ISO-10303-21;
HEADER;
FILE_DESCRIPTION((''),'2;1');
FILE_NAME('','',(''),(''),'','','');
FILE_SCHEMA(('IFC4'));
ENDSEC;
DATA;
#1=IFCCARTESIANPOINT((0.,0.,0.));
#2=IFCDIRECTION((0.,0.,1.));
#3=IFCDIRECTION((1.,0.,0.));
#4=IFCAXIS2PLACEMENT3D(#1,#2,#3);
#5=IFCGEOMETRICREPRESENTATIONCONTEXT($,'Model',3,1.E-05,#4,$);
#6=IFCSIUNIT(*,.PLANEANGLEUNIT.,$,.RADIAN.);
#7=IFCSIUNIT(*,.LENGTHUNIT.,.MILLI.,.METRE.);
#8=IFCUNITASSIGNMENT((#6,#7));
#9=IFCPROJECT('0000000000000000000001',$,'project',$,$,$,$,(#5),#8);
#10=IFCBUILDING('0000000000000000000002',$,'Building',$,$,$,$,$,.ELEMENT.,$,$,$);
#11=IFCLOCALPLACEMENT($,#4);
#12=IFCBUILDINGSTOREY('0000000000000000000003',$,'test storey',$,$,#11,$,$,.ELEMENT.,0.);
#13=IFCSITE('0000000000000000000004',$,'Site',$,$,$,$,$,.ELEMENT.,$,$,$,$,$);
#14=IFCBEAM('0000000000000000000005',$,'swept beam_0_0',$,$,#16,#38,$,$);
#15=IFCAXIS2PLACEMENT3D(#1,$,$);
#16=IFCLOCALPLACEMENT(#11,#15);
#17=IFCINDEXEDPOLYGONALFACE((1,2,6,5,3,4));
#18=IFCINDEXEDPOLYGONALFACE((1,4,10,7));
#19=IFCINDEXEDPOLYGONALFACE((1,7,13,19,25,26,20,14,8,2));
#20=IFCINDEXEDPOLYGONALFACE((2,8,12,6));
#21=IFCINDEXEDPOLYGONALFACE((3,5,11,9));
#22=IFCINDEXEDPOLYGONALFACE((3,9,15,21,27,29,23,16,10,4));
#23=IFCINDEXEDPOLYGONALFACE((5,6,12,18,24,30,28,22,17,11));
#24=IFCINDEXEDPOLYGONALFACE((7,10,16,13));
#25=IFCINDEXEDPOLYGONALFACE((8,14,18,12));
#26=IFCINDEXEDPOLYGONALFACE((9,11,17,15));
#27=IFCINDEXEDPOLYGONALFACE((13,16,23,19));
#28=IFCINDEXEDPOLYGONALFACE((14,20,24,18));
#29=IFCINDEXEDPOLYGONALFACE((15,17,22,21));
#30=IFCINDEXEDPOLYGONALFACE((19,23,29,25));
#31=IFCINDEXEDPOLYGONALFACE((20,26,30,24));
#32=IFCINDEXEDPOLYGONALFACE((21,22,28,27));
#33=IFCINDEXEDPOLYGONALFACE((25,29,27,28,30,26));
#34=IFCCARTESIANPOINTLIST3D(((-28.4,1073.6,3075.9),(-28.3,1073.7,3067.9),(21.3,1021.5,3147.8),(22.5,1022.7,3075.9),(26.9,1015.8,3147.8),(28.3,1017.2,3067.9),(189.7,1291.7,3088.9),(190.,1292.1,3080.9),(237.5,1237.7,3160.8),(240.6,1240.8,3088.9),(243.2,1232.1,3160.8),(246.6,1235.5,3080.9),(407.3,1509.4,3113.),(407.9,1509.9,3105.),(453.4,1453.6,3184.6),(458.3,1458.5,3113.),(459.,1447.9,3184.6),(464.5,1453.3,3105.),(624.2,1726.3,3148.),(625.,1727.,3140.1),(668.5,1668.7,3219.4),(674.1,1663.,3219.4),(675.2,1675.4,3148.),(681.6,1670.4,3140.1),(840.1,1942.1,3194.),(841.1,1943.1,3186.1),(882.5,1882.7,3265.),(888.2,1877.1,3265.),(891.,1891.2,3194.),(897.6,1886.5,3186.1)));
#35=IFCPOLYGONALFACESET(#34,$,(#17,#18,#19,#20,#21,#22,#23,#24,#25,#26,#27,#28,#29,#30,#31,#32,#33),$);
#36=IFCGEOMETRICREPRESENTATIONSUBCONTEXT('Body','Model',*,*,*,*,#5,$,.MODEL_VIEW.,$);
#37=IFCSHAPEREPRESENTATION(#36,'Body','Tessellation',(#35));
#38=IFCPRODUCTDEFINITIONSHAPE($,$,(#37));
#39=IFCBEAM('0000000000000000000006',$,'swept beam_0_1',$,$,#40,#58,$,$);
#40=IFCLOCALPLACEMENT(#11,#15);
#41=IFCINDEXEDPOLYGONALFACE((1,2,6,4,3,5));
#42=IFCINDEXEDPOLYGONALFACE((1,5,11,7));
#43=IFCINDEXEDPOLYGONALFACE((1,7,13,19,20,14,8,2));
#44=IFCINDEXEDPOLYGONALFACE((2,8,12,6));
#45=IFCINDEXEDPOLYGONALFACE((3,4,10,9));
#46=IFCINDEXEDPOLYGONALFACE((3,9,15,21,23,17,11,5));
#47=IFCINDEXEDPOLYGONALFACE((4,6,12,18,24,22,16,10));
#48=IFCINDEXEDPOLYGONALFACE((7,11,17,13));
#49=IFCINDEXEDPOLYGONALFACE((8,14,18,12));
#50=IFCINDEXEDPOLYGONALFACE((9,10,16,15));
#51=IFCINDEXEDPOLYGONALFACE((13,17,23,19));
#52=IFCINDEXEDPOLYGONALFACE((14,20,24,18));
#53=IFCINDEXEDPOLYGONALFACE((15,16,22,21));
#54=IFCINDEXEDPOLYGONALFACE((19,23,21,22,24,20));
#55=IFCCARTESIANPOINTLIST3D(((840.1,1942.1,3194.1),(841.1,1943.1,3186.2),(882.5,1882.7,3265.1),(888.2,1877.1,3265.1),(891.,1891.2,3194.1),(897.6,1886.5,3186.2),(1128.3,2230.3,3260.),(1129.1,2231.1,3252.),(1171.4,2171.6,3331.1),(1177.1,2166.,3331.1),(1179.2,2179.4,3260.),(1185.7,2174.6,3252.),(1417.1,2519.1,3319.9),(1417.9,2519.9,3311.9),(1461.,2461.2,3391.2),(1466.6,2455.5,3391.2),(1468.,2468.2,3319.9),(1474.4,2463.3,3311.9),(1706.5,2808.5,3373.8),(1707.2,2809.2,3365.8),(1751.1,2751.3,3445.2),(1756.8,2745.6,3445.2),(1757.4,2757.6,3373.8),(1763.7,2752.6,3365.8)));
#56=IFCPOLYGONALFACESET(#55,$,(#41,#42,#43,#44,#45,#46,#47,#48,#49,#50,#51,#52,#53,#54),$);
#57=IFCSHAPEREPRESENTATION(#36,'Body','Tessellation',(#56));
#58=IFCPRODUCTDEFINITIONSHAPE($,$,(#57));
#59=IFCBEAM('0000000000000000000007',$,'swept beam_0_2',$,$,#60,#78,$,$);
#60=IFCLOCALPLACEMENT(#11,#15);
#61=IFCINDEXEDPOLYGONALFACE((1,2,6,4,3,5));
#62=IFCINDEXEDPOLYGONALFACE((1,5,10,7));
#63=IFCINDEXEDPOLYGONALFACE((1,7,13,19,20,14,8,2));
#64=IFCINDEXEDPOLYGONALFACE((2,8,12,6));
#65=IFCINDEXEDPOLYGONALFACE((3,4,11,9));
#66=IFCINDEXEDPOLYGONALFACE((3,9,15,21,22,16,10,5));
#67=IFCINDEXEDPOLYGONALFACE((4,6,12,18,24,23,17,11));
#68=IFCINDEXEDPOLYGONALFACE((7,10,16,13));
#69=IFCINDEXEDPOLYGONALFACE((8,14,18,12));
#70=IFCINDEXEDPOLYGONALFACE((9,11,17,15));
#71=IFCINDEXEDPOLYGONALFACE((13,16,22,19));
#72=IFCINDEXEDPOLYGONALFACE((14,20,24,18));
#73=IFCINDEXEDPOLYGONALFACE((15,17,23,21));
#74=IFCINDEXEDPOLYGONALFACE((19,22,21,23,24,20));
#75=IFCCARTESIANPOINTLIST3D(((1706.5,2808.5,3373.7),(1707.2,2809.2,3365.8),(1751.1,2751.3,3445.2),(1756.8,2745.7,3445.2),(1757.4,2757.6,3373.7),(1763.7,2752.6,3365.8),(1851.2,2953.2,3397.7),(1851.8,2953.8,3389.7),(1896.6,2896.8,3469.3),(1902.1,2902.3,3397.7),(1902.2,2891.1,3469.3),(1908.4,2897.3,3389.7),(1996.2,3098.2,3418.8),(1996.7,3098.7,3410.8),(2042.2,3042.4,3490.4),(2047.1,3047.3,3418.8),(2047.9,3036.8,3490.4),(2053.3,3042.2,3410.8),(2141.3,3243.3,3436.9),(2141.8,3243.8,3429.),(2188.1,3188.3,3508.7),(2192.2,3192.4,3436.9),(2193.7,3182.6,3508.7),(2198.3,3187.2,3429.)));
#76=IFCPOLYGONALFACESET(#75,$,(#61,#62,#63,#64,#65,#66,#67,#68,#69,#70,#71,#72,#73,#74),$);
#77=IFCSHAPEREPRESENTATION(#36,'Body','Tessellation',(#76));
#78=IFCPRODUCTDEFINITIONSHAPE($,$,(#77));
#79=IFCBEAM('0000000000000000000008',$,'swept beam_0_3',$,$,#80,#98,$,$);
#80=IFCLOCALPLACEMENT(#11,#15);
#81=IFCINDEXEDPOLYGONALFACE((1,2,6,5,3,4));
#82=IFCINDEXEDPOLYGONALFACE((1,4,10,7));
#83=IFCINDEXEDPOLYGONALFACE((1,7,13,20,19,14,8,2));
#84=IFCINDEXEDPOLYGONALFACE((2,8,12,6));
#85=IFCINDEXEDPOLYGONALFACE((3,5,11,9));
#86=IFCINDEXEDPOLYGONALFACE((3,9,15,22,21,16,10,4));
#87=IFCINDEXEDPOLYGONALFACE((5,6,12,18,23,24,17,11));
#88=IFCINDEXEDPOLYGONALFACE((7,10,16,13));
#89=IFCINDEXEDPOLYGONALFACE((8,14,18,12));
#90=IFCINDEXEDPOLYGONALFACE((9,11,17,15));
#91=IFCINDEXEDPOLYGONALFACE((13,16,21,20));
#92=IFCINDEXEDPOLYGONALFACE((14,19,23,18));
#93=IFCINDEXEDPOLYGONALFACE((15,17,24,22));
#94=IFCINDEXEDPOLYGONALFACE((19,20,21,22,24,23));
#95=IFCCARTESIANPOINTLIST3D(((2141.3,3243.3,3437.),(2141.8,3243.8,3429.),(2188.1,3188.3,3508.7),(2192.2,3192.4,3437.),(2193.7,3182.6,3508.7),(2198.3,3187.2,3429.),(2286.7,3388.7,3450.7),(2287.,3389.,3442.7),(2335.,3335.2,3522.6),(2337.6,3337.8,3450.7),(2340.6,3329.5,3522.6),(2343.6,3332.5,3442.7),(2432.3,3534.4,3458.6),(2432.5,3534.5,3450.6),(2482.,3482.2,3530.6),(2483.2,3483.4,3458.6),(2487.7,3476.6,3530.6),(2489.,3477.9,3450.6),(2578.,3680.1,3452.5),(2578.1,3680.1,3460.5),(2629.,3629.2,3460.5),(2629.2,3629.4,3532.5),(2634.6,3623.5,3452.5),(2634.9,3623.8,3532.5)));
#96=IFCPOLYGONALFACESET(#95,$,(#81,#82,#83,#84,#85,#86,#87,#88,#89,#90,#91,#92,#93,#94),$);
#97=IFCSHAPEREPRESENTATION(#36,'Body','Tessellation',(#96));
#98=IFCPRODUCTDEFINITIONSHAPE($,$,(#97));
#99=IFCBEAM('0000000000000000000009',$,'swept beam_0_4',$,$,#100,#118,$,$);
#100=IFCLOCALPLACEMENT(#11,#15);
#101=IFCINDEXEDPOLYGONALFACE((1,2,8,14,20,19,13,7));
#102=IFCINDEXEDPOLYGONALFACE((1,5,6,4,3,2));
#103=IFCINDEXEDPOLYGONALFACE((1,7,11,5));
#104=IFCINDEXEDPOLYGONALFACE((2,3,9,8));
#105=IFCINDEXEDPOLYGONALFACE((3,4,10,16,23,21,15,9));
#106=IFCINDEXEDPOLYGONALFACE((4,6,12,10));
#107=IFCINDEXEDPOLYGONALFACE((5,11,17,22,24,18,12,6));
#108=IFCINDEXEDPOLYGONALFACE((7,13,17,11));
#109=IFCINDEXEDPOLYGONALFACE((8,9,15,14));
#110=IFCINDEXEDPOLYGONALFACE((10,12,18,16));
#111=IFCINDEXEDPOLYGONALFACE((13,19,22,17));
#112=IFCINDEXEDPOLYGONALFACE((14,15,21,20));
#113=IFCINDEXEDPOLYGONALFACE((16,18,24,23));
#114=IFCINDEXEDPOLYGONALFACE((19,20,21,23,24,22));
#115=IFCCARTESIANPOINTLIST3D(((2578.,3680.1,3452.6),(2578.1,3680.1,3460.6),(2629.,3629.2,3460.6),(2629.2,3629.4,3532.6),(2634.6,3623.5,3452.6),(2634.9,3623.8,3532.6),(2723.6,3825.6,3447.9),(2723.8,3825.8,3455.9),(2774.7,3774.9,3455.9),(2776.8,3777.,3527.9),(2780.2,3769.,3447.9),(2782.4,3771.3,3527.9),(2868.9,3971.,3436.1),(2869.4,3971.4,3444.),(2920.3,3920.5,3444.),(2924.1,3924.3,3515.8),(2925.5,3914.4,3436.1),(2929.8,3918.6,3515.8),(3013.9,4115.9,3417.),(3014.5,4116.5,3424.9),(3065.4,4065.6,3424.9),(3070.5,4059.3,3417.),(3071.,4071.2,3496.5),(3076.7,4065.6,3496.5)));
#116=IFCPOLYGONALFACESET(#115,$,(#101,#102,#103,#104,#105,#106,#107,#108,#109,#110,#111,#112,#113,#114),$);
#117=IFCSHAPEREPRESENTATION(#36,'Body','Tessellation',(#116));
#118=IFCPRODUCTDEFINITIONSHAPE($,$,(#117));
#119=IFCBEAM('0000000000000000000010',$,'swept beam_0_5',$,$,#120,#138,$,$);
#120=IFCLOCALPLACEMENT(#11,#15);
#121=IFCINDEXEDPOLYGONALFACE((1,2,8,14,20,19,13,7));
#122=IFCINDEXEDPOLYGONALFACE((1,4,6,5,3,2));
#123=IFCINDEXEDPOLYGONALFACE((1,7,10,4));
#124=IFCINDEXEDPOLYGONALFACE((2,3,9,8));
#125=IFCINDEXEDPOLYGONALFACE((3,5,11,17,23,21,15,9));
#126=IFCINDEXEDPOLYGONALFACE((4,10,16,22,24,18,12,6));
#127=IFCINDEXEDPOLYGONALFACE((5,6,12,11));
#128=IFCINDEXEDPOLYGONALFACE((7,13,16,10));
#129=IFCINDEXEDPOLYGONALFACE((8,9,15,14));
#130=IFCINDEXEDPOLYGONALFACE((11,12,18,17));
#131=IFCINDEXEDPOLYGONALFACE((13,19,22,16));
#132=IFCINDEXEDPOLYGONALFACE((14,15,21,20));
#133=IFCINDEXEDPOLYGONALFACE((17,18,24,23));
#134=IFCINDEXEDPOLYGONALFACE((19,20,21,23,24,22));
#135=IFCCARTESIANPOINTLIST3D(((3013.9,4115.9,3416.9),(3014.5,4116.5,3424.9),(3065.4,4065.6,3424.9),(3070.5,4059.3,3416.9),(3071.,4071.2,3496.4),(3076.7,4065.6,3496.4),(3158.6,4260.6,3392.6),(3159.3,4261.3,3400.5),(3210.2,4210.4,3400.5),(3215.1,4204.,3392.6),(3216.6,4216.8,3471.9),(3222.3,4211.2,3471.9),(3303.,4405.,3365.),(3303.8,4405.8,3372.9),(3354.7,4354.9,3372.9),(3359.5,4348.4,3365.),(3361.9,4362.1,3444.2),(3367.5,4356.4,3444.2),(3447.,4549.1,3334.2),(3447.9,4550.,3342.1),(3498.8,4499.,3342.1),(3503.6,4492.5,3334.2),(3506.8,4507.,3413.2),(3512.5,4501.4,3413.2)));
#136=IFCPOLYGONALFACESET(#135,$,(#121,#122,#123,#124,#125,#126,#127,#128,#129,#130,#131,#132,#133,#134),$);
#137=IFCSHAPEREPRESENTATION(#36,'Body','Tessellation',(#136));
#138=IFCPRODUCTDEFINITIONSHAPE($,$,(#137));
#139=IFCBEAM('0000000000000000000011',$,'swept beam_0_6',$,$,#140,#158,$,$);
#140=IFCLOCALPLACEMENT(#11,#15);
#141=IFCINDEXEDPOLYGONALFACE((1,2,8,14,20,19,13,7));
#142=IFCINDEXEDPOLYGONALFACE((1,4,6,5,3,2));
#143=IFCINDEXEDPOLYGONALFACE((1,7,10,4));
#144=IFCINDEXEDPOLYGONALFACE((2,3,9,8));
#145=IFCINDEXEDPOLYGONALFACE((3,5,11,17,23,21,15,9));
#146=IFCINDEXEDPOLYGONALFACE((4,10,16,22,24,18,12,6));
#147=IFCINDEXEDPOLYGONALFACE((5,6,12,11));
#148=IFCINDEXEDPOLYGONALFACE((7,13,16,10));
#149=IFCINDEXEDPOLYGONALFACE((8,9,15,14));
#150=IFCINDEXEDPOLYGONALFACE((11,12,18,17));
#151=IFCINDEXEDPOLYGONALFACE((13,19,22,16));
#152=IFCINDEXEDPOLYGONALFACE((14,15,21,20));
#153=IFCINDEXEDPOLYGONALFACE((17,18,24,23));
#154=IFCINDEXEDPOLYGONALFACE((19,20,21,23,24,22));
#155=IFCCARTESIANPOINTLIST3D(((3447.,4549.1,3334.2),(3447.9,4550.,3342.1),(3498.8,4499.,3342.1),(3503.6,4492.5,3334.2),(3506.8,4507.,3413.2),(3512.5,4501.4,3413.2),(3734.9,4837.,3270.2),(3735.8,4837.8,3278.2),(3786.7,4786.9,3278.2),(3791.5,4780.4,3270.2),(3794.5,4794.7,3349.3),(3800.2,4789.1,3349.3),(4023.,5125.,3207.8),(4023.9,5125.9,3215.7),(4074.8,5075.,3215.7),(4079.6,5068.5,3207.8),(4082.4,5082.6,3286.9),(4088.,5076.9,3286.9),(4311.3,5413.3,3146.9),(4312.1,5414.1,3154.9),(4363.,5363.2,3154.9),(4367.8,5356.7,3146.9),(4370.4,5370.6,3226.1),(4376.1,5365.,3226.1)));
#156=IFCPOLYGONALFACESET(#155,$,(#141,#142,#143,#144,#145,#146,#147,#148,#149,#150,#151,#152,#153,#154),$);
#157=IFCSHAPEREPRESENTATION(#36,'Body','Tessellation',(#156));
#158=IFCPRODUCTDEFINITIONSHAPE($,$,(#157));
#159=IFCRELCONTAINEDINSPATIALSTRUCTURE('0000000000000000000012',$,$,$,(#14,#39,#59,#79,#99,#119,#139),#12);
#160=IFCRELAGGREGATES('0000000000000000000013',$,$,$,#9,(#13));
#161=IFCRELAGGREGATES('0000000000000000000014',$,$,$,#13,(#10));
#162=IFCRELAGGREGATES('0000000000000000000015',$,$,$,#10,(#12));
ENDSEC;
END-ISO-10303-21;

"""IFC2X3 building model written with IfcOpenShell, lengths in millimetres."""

from ifc_helpers import new_model, entity, si_unit, origin_with_axes, place, context, subcontext, project, spatial, element, save


model = new_model("IFC2X3")

# Units and contexts
model_context = context("Model", 3, precision=1e-05, world=origin_with_axes())
body_context = subcontext(model_context, "Body", "Model", "MODEL_VIEW")
ifc_project = project(units=[si_unit("PLANEANGLEUNIT", "RADIAN"), si_unit("LENGTHUNIT", "METRE", prefix="MILLI")], contexts=[model_context])

# Site, building, storey
site = spatial("IfcSite", under=ifc_project, Name="Site", CompositionType="ELEMENT")
building = spatial("IfcBuilding", under=site, Name="Building", CompositionType="ELEMENT")
storey_placement = place(None, origin_with_axes())
storey = spatial("IfcBuildingStorey", under=building, at=storey_placement, Name="test storey", CompositionType="ELEMENT", Elevation=0.0)

# Beams
beam_1_placement = place(storey_placement, origin_with_axes())
element("IfcBeam", 1, at=beam_1_placement, inside=storey, Name="swept beam_0_0", context=body_context, shape_type="SweptSolid", body=[
    entity("IfcRevolvedAreaSolid", entity("IfcArbitraryClosedProfileDef", "AREA", None, entity("IfcPolyline", [entity("IfcCartesianPoint", [-80.0, 40.0]), entity("IfcCartesianPoint", [-80.0, 32.0]), entity("IfcCartesianPoint", [-8.0, 32.0]), entity("IfcCartesianPoint", [-8.0, -40.0]), entity("IfcCartesianPoint", [0.0, -40.0]), entity("IfcCartesianPoint", [0.0, 40.0]), entity("IfcCartesianPoint", [-80.0, 40.0])])), entity("IfcAxis2Placement3D", entity("IfcCartesianPoint", [0.0, 1045.5, 3067.9]), entity("IfcDirection", [-0.7069, -0.7069, -0.0243]), entity("IfcDirection", [0.0172, 0.0172, -0.9997])), entity("IfcAxis1Placement", entity("IfcCartesianPoint", [-8631.9, 0.0, 0.0]), entity("IfcDirection", [0.0, 1.0, 0.0])), 0.143208),
])
beam_2_placement = place(storey_placement, origin_with_axes())
element("IfcBeam", 2, at=beam_2_placement, inside=storey, Name="swept beam_0_1", context=body_context, shape_type="SweptSolid", body=[
    entity("IfcRevolvedAreaSolid", entity("IfcArbitraryClosedProfileDef", "AREA", None, entity("IfcPolyline", [entity("IfcCartesianPoint", [80.0, -40.0]), entity("IfcCartesianPoint", [80.0, -32.0]), entity("IfcCartesianPoint", [8.0, -32.0]), entity("IfcCartesianPoint", [8.0, 40.0]), entity("IfcCartesianPoint", [0.0, 40.0]), entity("IfcCartesianPoint", [0.0, -40.0]), entity("IfcCartesianPoint", [80.0, -40.0])])), entity("IfcAxis2Placement3D", entity("IfcCartesianPoint", [869.3, 1914.8, 3186.2]), entity("IfcDirection", [-0.6972, -0.6972, -0.1668]), entity("IfcDirection", [-0.1179, -0.1179, 0.986])), entity("IfcAxis1Placement", entity("IfcCartesianPoint", [-28206.8, 0.0, 0.0]), entity("IfcDirection", [0.0, 1.0, 0.0])), 0.043893),
])
beam_3_placement = place(storey_placement, origin_with_axes())
element("IfcBeam", 3, at=beam_3_placement, inside=storey, Name="swept beam_0_2", context=body_context, shape_type="SweptSolid", body=[
    entity("IfcRevolvedAreaSolid", entity("IfcArbitraryClosedProfileDef", "AREA", None, entity("IfcPolyline", [entity("IfcCartesianPoint", [80.0, -40.0]), entity("IfcCartesianPoint", [80.0, -32.0]), entity("IfcCartesianPoint", [8.0, -32.0]), entity("IfcCartesianPoint", [8.0, 40.0]), entity("IfcCartesianPoint", [0.0, 40.0]), entity("IfcCartesianPoint", [0.0, -40.0]), entity("IfcCartesianPoint", [80.0, -40.0])])), entity("IfcAxis2Placement3D", entity("IfcCartesianPoint", [1735.5, 2780.9, 3365.8]), entity("IfcDirection", [-0.7017, -0.7017, -0.1233]), entity("IfcDirection", [-0.0872, -0.0872, 0.9924])), entity("IfcAxis1Placement", entity("IfcCartesianPoint", [-14567.5, 0.0, 0.0]), entity("IfcDirection", [0.0, 1.0, 0.0])), 0.042416),
])
beam_4_placement = place(storey_placement, origin_with_axes())
element("IfcBeam", 4, at=beam_4_placement, inside=storey, Name="swept beam_0_3", context=body_context, shape_type="SweptSolid", body=[
    entity("IfcRevolvedAreaSolid", entity("IfcArbitraryClosedProfileDef", "AREA", None, entity("IfcPolyline", [entity("IfcCartesianPoint", [80.0, -40.0]), entity("IfcCartesianPoint", [80.0, -32.0]), entity("IfcCartesianPoint", [8.0, -32.0]), entity("IfcCartesianPoint", [8.0, 40.0]), entity("IfcCartesianPoint", [0.0, 40.0]), entity("IfcCartesianPoint", [0.0, -40.0]), entity("IfcCartesianPoint", [80.0, -40.0])])), entity("IfcAxis2Placement3D", entity("IfcCartesianPoint", [2170.1, 3215.5, 3429.0]), entity("IfcDirection", [-0.7048, -0.7048, -0.0811]), entity("IfcDirection", [-0.0574, -0.0574, 0.9967])), entity("IfcAxis1Placement", entity("IfcCartesianPoint", [-7175.2, 0.0, 0.0]), entity("IfcDirection", [0.0, 1.0, 0.0])), 0.086075),
])
beam_5_placement = place(storey_placement, origin_with_axes())
element("IfcBeam", 5, at=beam_5_placement, inside=storey, Name="swept beam_0_4", context=body_context, shape_type="SweptSolid", body=[
    entity("IfcRevolvedAreaSolid", entity("IfcArbitraryClosedProfileDef", "AREA", None, entity("IfcPolyline", [entity("IfcCartesianPoint", [80.0, -40.0]), entity("IfcCartesianPoint", [80.0, -32.0]), entity("IfcCartesianPoint", [8.0, -32.0]), entity("IfcCartesianPoint", [8.0, 40.0]), entity("IfcCartesianPoint", [0.0, 40.0]), entity("IfcCartesianPoint", [0.0, -40.0]), entity("IfcCartesianPoint", [80.0, -40.0])])), entity("IfcAxis2Placement3D", entity("IfcCartesianPoint", [2606.3, 3651.8, 3452.6]), entity("IfcDirection", [-0.7071, -0.7071, 0.0048]), entity("IfcDirection", [0.0034, 0.0034, 1.0])), entity("IfcAxis1Placement", entity("IfcCartesianPoint", [-5839.2, 0.0, 0.0]), entity("IfcDirection", [0.0, 1.0, 0.0])), 0.105788),
])
beam_6_placement = place(storey_placement, origin_with_axes())
element("IfcBeam", 6, at=beam_6_placement, inside=storey, Name="swept beam_0_5", context=body_context, shape_type="SweptSolid", body=[
    entity("IfcRevolvedAreaSolid", entity("IfcArbitraryClosedProfileDef", "AREA", None, entity("IfcPolyline", [entity("IfcCartesianPoint", [80.0, -40.0]), entity("IfcCartesianPoint", [80.0, -32.0]), entity("IfcCartesianPoint", [8.0, -32.0]), entity("IfcCartesianPoint", [8.0, 40.0]), entity("IfcCartesianPoint", [0.0, 40.0]), entity("IfcCartesianPoint", [0.0, -40.0]), entity("IfcCartesianPoint", [80.0, -40.0])])), entity("IfcAxis2Placement3D", entity("IfcCartesianPoint", [3042.2, 4087.6, 3416.9]), entity("IfcDirection", [-0.7028, -0.7028, 0.1104]), entity("IfcDirection", [0.0781, 0.0781, 0.9939])), entity("IfcAxis1Placement", entity("IfcCartesianPoint", [-13109.2, 0.0, 0.0]), entity("IfcDirection", [0.0, 1.0, 0.0])), 0.047156),
])
beam_7_placement = place(storey_placement, origin_with_axes())
element("IfcBeam", 7, at=beam_7_placement, inside=storey, Name="swept beam_0_6", context=body_context, shape_type="SweptSolid", body=[
    entity("IfcRevolvedAreaSolid", entity("IfcArbitraryClosedProfileDef", "AREA", None, entity("IfcPolyline", [entity("IfcCartesianPoint", [-80.0, 40.0]), entity("IfcCartesianPoint", [-80.0, 32.0]), entity("IfcCartesianPoint", [-8.0, 32.0]), entity("IfcCartesianPoint", [-8.0, -40.0]), entity("IfcCartesianPoint", [0.0, -40.0]), entity("IfcCartesianPoint", [0.0, 40.0]), entity("IfcCartesianPoint", [-80.0, 40.0])])), entity("IfcAxis2Placement3D", entity("IfcCartesianPoint", [3475.3, 4520.8, 3334.2]), entity("IfcDirection", [-0.6983, -0.6983, 0.1571]), entity("IfcDirection", [-0.1111, -0.1111, -0.9876])), entity("IfcAxis1Placement", entity("IfcCartesianPoint", [-108337.8, 0.0, 0.0]), entity("IfcDirection", [0.0, 1.0, 0.0])), 0.011413),
])

save(model, "model.ifc")
